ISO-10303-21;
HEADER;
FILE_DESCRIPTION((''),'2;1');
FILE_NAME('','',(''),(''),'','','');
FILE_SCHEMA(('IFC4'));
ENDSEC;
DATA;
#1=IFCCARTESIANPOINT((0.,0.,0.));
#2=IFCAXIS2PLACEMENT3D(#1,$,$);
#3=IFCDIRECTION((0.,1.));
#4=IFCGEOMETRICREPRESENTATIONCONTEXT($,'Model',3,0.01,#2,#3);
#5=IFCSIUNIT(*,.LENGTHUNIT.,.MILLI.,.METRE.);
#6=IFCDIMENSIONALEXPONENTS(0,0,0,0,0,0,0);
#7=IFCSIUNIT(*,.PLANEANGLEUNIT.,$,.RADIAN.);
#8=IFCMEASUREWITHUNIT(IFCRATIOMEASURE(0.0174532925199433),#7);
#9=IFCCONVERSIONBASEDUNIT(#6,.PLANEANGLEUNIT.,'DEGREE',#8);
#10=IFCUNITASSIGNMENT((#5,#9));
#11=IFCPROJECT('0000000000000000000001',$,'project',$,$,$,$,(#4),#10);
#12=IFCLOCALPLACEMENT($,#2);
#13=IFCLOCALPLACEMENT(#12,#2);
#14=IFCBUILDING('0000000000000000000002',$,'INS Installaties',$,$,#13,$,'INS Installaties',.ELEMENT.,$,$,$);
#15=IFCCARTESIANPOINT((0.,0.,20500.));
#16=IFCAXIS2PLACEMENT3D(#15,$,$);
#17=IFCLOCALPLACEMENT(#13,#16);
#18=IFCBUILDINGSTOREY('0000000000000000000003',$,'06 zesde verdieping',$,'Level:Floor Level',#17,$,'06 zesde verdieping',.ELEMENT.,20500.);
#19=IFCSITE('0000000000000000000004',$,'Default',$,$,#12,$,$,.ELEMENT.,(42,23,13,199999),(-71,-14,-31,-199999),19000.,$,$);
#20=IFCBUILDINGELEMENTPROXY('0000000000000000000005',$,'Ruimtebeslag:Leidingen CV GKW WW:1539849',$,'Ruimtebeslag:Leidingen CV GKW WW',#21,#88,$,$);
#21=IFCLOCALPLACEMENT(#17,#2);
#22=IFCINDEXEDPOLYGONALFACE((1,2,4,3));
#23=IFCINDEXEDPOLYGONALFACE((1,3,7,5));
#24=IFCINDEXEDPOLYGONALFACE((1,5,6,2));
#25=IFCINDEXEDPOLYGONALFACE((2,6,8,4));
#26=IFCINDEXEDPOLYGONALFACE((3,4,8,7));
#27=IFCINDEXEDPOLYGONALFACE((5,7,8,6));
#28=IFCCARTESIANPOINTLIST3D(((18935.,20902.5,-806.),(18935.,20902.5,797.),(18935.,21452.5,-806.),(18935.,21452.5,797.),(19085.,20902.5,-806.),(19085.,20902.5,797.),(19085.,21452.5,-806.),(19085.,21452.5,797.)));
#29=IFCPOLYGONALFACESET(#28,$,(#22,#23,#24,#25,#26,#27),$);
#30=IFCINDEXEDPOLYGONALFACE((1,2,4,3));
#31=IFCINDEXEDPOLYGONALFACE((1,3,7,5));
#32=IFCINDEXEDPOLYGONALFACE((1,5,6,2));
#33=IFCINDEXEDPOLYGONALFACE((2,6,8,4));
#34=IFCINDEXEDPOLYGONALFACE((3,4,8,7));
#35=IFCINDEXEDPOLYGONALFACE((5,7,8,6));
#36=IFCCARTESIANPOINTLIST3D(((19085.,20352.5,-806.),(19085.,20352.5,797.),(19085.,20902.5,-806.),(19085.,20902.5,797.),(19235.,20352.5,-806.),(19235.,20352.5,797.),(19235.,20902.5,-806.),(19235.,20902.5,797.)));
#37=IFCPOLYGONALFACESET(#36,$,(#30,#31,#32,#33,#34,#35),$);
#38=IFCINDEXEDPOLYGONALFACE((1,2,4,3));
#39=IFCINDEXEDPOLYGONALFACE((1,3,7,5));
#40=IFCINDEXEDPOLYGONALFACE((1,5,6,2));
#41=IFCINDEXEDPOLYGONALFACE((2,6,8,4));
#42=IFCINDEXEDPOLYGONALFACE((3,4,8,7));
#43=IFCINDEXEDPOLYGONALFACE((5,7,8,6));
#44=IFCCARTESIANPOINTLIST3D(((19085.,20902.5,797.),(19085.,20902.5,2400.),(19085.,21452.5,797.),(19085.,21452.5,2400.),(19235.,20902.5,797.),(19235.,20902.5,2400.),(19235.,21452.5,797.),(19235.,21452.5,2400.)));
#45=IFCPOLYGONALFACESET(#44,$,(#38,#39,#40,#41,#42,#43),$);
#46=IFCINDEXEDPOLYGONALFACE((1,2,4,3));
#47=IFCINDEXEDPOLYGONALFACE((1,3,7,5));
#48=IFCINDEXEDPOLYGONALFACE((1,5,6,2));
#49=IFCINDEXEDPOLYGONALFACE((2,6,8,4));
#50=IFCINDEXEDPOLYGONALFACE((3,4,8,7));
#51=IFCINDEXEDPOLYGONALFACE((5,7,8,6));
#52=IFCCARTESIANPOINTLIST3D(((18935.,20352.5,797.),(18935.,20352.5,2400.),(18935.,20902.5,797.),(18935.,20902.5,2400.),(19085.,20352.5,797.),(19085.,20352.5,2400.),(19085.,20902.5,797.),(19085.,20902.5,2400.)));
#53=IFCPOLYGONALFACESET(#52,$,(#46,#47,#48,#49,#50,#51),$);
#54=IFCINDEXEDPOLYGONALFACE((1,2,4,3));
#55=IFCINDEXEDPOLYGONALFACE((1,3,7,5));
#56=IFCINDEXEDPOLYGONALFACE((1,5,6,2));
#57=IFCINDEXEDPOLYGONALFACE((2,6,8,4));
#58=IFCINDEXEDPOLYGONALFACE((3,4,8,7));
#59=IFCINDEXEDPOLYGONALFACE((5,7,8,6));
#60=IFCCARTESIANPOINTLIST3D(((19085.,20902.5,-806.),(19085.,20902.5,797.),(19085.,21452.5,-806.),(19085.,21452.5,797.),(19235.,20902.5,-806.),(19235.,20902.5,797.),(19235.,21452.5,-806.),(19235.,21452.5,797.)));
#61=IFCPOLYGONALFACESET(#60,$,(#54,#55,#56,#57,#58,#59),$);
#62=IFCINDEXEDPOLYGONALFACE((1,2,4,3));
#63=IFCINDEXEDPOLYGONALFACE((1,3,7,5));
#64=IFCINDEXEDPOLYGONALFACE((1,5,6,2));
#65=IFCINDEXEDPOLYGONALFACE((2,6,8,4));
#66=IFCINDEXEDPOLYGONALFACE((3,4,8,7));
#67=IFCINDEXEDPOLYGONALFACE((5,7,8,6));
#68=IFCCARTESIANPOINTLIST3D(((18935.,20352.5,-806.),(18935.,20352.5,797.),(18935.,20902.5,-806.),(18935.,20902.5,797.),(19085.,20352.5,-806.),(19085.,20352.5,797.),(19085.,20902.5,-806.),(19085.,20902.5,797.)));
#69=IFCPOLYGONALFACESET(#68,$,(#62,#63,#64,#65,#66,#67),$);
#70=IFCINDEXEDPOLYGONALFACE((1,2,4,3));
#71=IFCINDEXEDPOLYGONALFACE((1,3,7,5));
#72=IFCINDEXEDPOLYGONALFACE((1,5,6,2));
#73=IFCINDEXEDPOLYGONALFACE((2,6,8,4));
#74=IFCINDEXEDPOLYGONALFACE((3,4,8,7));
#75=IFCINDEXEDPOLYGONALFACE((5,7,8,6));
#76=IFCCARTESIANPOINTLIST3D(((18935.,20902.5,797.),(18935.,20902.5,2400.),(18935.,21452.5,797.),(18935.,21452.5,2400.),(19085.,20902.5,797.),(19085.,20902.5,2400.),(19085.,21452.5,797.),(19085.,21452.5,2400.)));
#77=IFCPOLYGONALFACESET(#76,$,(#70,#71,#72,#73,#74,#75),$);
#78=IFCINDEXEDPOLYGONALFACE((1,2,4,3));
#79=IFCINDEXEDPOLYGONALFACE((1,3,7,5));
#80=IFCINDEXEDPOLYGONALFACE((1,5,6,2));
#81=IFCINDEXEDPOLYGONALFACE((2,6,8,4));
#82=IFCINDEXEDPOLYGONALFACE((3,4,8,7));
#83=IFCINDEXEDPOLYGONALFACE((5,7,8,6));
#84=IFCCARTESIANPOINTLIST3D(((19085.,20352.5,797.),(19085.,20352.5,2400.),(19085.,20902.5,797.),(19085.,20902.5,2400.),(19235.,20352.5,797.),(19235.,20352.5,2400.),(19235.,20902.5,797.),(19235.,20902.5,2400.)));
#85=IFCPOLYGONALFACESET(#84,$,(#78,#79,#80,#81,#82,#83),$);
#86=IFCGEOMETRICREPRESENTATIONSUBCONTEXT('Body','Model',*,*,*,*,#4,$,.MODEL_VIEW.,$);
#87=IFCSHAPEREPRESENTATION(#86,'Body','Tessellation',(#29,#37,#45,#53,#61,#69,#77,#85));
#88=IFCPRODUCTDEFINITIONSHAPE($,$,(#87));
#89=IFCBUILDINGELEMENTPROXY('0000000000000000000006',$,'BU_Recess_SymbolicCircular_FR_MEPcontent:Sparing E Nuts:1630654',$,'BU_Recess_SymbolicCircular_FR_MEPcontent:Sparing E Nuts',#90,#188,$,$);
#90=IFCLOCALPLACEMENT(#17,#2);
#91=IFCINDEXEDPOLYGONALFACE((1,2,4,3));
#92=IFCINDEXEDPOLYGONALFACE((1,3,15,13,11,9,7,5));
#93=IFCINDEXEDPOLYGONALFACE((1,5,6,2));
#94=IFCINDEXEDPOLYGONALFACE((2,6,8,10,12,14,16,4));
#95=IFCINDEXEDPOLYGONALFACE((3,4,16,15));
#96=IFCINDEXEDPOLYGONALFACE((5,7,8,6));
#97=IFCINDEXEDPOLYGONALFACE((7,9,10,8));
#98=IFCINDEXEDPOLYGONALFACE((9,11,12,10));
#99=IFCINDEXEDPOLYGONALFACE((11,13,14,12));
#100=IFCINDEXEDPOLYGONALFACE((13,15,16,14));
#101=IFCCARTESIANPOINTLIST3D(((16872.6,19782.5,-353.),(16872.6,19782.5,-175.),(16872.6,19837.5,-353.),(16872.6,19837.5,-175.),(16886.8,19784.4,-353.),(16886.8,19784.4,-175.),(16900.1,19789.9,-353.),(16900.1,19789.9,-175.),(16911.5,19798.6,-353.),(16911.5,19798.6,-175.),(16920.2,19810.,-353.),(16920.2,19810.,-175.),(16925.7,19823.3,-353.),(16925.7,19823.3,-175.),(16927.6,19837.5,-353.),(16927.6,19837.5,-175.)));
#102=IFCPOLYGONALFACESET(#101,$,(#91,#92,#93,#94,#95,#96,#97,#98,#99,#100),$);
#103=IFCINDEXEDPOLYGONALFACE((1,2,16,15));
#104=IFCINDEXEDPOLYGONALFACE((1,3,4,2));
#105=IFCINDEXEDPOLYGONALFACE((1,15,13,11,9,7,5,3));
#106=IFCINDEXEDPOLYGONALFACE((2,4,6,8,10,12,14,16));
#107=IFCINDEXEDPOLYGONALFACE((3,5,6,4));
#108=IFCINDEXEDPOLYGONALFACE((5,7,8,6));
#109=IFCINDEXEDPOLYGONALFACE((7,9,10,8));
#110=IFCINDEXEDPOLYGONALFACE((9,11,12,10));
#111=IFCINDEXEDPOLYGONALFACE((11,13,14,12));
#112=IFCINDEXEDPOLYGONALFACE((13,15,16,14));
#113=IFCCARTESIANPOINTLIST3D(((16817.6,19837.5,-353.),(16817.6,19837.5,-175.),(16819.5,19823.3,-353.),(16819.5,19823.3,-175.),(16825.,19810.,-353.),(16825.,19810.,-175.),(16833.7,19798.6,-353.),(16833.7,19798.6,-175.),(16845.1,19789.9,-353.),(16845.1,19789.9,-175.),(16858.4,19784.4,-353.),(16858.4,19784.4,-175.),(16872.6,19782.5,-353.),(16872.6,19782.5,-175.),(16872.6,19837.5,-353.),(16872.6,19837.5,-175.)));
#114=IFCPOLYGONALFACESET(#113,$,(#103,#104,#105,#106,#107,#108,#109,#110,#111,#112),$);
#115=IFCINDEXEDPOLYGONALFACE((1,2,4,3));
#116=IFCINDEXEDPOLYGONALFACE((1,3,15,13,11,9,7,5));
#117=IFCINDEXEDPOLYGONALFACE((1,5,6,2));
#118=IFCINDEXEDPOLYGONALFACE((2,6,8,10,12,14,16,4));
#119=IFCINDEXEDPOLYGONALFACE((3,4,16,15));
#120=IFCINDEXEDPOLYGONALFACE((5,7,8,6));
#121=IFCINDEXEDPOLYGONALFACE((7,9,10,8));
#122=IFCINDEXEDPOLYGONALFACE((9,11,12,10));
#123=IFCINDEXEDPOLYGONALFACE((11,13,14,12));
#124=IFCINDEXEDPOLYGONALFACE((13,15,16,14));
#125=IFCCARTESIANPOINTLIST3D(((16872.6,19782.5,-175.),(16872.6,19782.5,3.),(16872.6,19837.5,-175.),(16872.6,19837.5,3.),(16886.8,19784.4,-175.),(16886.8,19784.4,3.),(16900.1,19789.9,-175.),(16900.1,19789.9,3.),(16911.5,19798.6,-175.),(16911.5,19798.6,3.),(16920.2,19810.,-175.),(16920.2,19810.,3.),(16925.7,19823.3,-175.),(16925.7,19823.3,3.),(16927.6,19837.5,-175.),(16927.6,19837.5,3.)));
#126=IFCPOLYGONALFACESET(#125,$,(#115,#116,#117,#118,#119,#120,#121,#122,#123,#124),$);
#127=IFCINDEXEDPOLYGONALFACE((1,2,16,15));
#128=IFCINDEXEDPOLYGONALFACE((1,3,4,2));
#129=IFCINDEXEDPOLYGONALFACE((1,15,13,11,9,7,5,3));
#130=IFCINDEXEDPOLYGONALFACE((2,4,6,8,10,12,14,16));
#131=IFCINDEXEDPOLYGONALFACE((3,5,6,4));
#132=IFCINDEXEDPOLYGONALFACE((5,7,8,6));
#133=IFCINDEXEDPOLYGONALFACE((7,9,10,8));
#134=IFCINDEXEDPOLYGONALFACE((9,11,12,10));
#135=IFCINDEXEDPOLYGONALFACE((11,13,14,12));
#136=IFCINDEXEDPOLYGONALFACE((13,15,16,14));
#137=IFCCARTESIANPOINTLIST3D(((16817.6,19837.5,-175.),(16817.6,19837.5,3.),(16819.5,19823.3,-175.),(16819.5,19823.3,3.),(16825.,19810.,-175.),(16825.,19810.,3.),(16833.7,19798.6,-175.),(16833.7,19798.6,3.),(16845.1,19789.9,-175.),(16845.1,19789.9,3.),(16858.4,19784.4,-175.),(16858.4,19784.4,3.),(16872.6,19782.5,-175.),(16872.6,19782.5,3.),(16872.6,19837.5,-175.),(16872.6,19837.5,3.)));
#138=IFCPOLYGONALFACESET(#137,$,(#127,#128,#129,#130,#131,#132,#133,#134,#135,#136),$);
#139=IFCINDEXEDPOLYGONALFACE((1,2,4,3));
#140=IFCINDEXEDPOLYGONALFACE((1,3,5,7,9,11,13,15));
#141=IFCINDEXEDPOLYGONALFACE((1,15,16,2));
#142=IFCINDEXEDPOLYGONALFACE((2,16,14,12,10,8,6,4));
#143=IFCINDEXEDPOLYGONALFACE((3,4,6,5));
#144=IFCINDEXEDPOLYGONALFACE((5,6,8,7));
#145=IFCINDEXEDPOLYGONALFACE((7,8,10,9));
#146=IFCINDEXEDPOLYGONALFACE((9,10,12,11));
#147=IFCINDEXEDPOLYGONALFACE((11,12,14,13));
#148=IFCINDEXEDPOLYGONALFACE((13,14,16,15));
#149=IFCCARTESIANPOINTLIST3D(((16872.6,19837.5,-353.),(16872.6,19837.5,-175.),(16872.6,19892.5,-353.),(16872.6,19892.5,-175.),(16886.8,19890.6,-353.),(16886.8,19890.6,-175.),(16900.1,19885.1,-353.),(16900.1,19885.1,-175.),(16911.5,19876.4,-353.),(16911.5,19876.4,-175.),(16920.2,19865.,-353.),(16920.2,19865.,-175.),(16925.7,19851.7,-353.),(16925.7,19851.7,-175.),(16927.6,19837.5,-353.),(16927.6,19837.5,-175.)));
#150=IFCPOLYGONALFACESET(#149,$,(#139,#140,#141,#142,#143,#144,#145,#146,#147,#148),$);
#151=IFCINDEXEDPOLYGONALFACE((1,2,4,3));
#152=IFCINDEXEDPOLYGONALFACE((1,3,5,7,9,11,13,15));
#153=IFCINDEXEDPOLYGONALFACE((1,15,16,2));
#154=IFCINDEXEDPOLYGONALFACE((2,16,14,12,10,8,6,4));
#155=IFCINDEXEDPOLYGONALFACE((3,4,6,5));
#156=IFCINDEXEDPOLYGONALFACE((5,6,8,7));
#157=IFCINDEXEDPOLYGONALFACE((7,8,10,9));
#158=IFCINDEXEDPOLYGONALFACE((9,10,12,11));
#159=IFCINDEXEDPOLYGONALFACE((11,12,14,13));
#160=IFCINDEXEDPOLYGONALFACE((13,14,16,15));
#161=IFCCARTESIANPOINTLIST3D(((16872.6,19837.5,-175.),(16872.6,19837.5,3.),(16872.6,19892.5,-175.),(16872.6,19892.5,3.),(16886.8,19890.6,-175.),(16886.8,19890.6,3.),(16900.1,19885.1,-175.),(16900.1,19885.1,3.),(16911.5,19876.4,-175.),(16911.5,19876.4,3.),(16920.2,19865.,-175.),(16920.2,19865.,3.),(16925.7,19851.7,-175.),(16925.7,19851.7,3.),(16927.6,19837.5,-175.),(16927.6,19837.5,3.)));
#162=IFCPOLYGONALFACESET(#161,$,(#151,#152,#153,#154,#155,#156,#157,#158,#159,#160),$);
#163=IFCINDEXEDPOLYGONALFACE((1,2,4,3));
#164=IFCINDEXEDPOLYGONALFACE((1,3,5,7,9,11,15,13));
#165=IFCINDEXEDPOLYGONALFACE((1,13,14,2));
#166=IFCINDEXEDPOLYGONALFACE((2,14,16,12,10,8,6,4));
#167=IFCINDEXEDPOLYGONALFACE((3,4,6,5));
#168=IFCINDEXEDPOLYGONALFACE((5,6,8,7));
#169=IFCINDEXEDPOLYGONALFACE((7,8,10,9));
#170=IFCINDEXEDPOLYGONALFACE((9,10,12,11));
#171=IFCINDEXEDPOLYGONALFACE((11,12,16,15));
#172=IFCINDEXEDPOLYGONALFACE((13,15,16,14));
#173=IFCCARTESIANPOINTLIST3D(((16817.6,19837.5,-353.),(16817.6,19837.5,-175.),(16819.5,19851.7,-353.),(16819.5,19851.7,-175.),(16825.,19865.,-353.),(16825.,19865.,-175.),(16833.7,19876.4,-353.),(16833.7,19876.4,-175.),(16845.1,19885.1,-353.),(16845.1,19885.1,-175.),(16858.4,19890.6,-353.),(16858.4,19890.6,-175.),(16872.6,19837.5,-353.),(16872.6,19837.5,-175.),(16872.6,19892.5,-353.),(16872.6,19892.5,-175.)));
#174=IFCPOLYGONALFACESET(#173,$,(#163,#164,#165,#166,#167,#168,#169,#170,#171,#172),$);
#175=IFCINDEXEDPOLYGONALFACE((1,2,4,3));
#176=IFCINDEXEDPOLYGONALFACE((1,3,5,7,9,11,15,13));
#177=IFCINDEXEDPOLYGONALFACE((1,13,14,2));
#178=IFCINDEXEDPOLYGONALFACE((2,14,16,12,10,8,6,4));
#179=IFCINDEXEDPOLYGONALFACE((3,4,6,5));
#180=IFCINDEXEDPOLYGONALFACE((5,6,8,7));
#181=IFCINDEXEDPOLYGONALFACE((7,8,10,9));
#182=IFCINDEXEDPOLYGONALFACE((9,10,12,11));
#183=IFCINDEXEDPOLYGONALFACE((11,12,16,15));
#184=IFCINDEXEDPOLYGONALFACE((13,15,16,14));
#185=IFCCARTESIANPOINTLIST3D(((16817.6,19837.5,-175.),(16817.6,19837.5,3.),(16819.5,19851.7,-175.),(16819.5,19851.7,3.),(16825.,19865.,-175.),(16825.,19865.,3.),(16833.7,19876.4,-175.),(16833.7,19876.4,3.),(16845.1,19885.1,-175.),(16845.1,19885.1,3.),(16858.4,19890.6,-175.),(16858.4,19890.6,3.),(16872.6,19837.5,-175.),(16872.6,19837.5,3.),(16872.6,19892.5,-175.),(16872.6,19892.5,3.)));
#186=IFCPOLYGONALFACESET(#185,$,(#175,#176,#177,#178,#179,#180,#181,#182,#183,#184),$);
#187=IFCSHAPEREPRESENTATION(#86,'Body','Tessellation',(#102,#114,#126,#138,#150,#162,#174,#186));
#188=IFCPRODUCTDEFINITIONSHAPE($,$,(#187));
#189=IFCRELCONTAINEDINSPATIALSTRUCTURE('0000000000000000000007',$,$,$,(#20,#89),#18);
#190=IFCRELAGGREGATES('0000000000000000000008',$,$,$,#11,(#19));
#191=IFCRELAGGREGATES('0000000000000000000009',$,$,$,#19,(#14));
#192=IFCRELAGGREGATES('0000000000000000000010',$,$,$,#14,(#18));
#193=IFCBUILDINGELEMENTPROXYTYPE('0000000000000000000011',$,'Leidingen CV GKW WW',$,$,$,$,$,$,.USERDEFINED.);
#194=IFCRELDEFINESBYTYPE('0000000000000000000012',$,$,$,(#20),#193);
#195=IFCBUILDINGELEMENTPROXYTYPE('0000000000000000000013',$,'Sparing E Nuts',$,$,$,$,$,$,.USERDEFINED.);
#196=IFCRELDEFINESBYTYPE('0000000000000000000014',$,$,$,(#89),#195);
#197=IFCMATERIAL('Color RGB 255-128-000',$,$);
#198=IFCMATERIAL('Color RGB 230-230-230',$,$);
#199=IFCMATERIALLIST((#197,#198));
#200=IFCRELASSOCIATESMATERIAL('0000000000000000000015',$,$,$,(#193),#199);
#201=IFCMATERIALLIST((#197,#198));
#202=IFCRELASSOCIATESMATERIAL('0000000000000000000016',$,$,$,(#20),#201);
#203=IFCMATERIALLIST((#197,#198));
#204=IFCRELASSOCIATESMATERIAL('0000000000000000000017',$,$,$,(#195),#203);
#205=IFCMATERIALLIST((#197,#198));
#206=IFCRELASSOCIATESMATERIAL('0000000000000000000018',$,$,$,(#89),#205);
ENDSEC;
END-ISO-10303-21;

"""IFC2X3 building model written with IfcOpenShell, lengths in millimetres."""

from ifc_helpers import new_model, entity, si_unit, converted_unit, direction, frame, frame_2d, origin, origin_2d_with_axis, place, context, subcontext, project, spatial, polyline, circle_curve, parameter, trimmed, segment, composite_curve, rectangle, outline, extrude, source, transform, mapped, material, material_list, type_object, type_shapes, element, save


model = new_model("IFC2X3")

# Units and contexts
model_context = context("Model", 3, precision=0.01, world=origin(), true_north=direction((0.0, 1.0)))
body_context = subcontext(model_context, "Body", "Model", "MODEL_VIEW")
ifc_project = project(units=[si_unit("LENGTHUNIT", "METRE", prefix="MILLI"), converted_unit("PLANEANGLEUNIT", "DEGREE", entity("IfcRatioMeasure", 0.0174532925199433), si_unit("PLANEANGLEUNIT", "RADIAN"), dimensions=[0, 0, 0, 0, 0, 0, 0])], contexts=[model_context])

# Site, building, storey
site_placement = place(None, origin())
site = spatial("IfcSite", under=ifc_project, at=site_placement, Name="Default", CompositionType="ELEMENT", RefLatitude=(42, 23, 13, 199999), RefLongitude=(-71, -14, -31, -199999), RefElevation=19000.0)
building_placement = place(site_placement, origin())
building = spatial("IfcBuilding", under=site, at=building_placement, Name="INS Installaties", LongName="INS Installaties", CompositionType="ELEMENT")
storey_placement = place(building_placement, frame((0.0, 0.0, 20500.0)))
storey = spatial("IfcBuildingStorey", under=building, at=storey_placement, Name="06 zesde verdieping", ObjectType="Level:Floor Level", LongName="06 zesde verdieping", CompositionType="ELEMENT", Elevation=20500.0)

# Building element proxies
ifc_material_1 = material(Name="Color RGB 255-128-000")
ifc_material_2 = material(Name="Color RGB 230-230-230")
ifc_material_list_1 = material_list([ifc_material_1, ifc_material_2])
ifc_material_list_2 = material_list([ifc_material_1, ifc_material_2])
building_element_proxy_type_1 = type_object("IfcBuildingElementProxyType", Name="Leidingen CV GKW WW", PredefinedType="USERDEFINED", material=ifc_material_list_2)
shared_shape_1 = source(origin(), body_context, "Body", "SweptSolid", [
    extrude(rectangle(XDim=150.0, YDim=550.0, at=frame_2d((0.0, 0.0), x_axis=(1.0, 0.0))), frame((75.0, -275.0, -3203.0)), (0.0, 0.0, 1.0), 1603.0),
    extrude(rectangle(XDim=150.0, YDim=550.0, at=origin_2d_with_axis()), frame((-75.0, 275.0, -3203.0), z_axis=(0.0, 0.0, 1.0), x_axis=(-1.0, 0.0, 0.0)), (0.0, 0.0, 1.0), 1603.0),
    extrude(rectangle(XDim=550.0, YDim=150.0, at=frame_2d((0.0, 0.0), x_axis=(1.0, 0.0))), frame((-75.0, -275.0, -1600.0), z_axis=(0.0, 0.0, 1.0), x_axis=(0.0, 1.0, 0.0)), (0.0, 0.0, 1.0), 1603.0),
    extrude(rectangle(XDim=550.0, YDim=150.0, at=origin_2d_with_axis()), frame((75.0, 275.0, -1600.0), z_axis=(0.0, 0.0, 1.0), x_axis=(0.0, -1.0, 0.0)), (0.0, 0.0, 1.0), 1603.0),
    extrude(rectangle(XDim=550.0, YDim=150.0, at=origin_2d_with_axis()), frame((-75.0, -275.0, -3203.0), z_axis=(0.0, 0.0, 1.0), x_axis=(0.0, 1.0, 0.0)), (0.0, 0.0, 1.0), 1603.0),
    extrude(rectangle(XDim=550.0, YDim=150.0, at=origin_2d_with_axis()), frame((75.0, 275.0, -3203.0), z_axis=(0.0, 0.0, 1.0), x_axis=(0.0, -1.0, 0.0)), (0.0, 0.0, 1.0), 1603.0),
    extrude(rectangle(XDim=150.0, YDim=550.0, at=frame_2d((0.0, 0.0), x_axis=(1.0, 0.0))), frame((75.0, -275.0, -1600.0)), (0.0, 0.0, 1.0), 1603.0),
    extrude(rectangle(XDim=150.0, YDim=550.0, at=origin_2d_with_axis()), frame((-75.0, 275.0, -1600.0), z_axis=(0.0, 0.0, 1.0), x_axis=(-1.0, 0.0, 0.0)), (0.0, 0.0, 1.0), 1603.0),
])
type_shapes(building_element_proxy_type_1, [shared_shape_1])
proxy_1_placement = place(storey_placement, frame((19085.0, 20902.5, 2397.0), z_axis=(0.0, 0.0, 1.0), x_axis=(-1.0, 0.0, 0.0)))
element("IfcBuildingElementProxy", 1, at=proxy_1_placement, inside=storey, type_object=building_element_proxy_type_1, material=ifc_material_list_1, Name="Ruimtebeslag:Leidingen CV GKW WW:1539849", ObjectType="Ruimtebeslag:Leidingen CV GKW WW", context=body_context, shape_type="MappedRepresentation", body=[
    mapped(shared_shape_1, transform((0.0, 0.0, 0.0), scale=1.0)),
])
ifc_material_list_3 = material_list([ifc_material_1, ifc_material_2])
ifc_material_list_4 = material_list([ifc_material_1, ifc_material_2])
building_element_proxy_type_2 = type_object("IfcBuildingElementProxyType", Name="Sparing E Nuts", PredefinedType="USERDEFINED", material=ifc_material_list_4)
shared_shape_2 = source(origin(), body_context, "Body", "SweptSolid", [
    extrude(outline(composite_curve([segment(polyline([(-36.7, -18.3), (18.3, -18.3)]), True, "CONTINUOUS"), segment(polyline([(18.3, -18.3), (18.3, 36.7)]), True, "CONTINUOUS"), segment(trimmed(circle_curve(frame_2d((18.3, -18.3), x_axis=(1.0, 0.0)), 55.0), [parameter(90.0)], [parameter(180.0)], True, "PARAMETER"), True, "CONTINUOUS")], self_intersect=False)), frame((18.3, -18.3, -353.0), z_axis=(0.0, 0.0, 1.0), x_axis=(-1.0, 0.0, 0.0)), (0.0, 0.0, 1.0), 178.0),
    extrude(outline(composite_curve([segment(trimmed(circle_curve(frame_2d((18.3, 18.3), x_axis=(1.0, 0.0)), 55.0), [parameter(180.0)], [parameter(270.0)], True, "PARAMETER"), True, "CONTINUOUS"), segment(polyline([(18.3, -36.7), (18.3, 18.3)]), True, "CONTINUOUS"), segment(polyline([(18.3, 18.3), (-36.7, 18.3)]), True, "CONTINUOUS")], self_intersect=False)), frame((-18.3, -18.3, -353.0)), (0.0, 0.0, 1.0), 178.0),
    extrude(outline(composite_curve([segment(polyline([(-36.7, -18.3), (18.3, -18.3)]), True, "CONTINUOUS"), segment(polyline([(18.3, -18.3), (18.3, 36.7)]), True, "CONTINUOUS"), segment(trimmed(circle_curve(frame_2d((18.3, -18.3), x_axis=(1.0, 0.0)), 55.0), [parameter(90.0)], [parameter(180.0)], True, "PARAMETER"), True, "CONTINUOUS")], self_intersect=False)), frame((18.3, -18.3, -175.0), z_axis=(0.0, 0.0, 1.0), x_axis=(-1.0, 0.0, 0.0)), (0.0, 0.0, 1.0), 178.0),
    extrude(outline(composite_curve([segment(trimmed(circle_curve(frame_2d((18.3, 18.3), x_axis=(1.0, 0.0)), 55.0), [parameter(180.0)], [parameter(270.0)], True, "PARAMETER"), True, "CONTINUOUS"), segment(polyline([(18.3, -36.7), (18.3, 18.3)]), True, "CONTINUOUS"), segment(polyline([(18.3, 18.3), (-36.7, 18.3)]), True, "CONTINUOUS")], self_intersect=False)), frame((-18.3, -18.3, -175.0)), (0.0, 0.0, 1.0), 178.0),
    extrude(outline(composite_curve([segment(trimmed(circle_curve(frame_2d((18.3, 18.3), x_axis=(1.0, 0.0)), 55.0), [parameter(180.0)], [parameter(270.0)], True, "PARAMETER"), True, "CONTINUOUS"), segment(polyline([(18.3, -36.7), (18.3, 18.3)]), True, "CONTINUOUS"), segment(polyline([(18.3, 18.3), (-36.7, 18.3)]), True, "CONTINUOUS")], self_intersect=False)), frame((18.3, 18.3, -353.0), z_axis=(0.0, 0.0, 1.0), x_axis=(-1.0, 0.0, 0.0)), (0.0, 0.0, 1.0), 178.0),
    extrude(outline(composite_curve([segment(trimmed(circle_curve(frame_2d((18.3, 18.3), x_axis=(1.0, 0.0)), 55.0), [parameter(180.0)], [parameter(270.0)], True, "PARAMETER"), True, "CONTINUOUS"), segment(polyline([(18.3, -36.7), (18.3, 18.3)]), True, "CONTINUOUS"), segment(polyline([(18.3, 18.3), (-36.7, 18.3)]), True, "CONTINUOUS")], self_intersect=False)), frame((18.3, 18.3, -175.0), z_axis=(0.0, 0.0, 1.0), x_axis=(-1.0, 0.0, 0.0)), (0.0, 0.0, 1.0), 178.0),
    extrude(outline(composite_curve([segment(polyline([(-36.7, -18.3), (18.3, -18.3)]), True, "CONTINUOUS"), segment(polyline([(18.3, -18.3), (18.3, 36.7)]), True, "CONTINUOUS"), segment(trimmed(circle_curve(frame_2d((18.3, -18.3), x_axis=(1.0, 0.0)), 55.0), [parameter(90.0)], [parameter(180.0)], True, "PARAMETER"), True, "CONTINUOUS")], self_intersect=False)), frame((-18.3, 18.3, -353.0)), (0.0, 0.0, 1.0), 178.0),
    extrude(outline(composite_curve([segment(polyline([(-36.7, -18.3), (18.3, -18.3)]), True, "CONTINUOUS"), segment(polyline([(18.3, -18.3), (18.3, 36.7)]), True, "CONTINUOUS"), segment(trimmed(circle_curve(frame_2d((18.3, -18.3), x_axis=(1.0, 0.0)), 55.0), [parameter(90.0)], [parameter(180.0)], True, "PARAMETER"), True, "CONTINUOUS")], self_intersect=False)), frame((-18.3, 18.3, -175.0)), (0.0, 0.0, 1.0), 178.0),
])
type_shapes(building_element_proxy_type_2, [shared_shape_2])
proxy_2_placement = place(storey_placement, frame((16872.6, 19837.5, 0.0)))
element("IfcBuildingElementProxy", 2, at=proxy_2_placement, inside=storey, type_object=building_element_proxy_type_2, material=ifc_material_list_3, Name="BU_Recess_SymbolicCircular_FR_MEPcontent:Sparing E Nuts:1630654", ObjectType="BU_Recess_SymbolicCircular_FR_MEPcontent:Sparing E Nuts", context=body_context, shape_type="MappedRepresentation", body=[
    mapped(shared_shape_2, transform((0.0, 0.0, 0.0), scale=1.0)),
])

save(model, "model.ifc")
